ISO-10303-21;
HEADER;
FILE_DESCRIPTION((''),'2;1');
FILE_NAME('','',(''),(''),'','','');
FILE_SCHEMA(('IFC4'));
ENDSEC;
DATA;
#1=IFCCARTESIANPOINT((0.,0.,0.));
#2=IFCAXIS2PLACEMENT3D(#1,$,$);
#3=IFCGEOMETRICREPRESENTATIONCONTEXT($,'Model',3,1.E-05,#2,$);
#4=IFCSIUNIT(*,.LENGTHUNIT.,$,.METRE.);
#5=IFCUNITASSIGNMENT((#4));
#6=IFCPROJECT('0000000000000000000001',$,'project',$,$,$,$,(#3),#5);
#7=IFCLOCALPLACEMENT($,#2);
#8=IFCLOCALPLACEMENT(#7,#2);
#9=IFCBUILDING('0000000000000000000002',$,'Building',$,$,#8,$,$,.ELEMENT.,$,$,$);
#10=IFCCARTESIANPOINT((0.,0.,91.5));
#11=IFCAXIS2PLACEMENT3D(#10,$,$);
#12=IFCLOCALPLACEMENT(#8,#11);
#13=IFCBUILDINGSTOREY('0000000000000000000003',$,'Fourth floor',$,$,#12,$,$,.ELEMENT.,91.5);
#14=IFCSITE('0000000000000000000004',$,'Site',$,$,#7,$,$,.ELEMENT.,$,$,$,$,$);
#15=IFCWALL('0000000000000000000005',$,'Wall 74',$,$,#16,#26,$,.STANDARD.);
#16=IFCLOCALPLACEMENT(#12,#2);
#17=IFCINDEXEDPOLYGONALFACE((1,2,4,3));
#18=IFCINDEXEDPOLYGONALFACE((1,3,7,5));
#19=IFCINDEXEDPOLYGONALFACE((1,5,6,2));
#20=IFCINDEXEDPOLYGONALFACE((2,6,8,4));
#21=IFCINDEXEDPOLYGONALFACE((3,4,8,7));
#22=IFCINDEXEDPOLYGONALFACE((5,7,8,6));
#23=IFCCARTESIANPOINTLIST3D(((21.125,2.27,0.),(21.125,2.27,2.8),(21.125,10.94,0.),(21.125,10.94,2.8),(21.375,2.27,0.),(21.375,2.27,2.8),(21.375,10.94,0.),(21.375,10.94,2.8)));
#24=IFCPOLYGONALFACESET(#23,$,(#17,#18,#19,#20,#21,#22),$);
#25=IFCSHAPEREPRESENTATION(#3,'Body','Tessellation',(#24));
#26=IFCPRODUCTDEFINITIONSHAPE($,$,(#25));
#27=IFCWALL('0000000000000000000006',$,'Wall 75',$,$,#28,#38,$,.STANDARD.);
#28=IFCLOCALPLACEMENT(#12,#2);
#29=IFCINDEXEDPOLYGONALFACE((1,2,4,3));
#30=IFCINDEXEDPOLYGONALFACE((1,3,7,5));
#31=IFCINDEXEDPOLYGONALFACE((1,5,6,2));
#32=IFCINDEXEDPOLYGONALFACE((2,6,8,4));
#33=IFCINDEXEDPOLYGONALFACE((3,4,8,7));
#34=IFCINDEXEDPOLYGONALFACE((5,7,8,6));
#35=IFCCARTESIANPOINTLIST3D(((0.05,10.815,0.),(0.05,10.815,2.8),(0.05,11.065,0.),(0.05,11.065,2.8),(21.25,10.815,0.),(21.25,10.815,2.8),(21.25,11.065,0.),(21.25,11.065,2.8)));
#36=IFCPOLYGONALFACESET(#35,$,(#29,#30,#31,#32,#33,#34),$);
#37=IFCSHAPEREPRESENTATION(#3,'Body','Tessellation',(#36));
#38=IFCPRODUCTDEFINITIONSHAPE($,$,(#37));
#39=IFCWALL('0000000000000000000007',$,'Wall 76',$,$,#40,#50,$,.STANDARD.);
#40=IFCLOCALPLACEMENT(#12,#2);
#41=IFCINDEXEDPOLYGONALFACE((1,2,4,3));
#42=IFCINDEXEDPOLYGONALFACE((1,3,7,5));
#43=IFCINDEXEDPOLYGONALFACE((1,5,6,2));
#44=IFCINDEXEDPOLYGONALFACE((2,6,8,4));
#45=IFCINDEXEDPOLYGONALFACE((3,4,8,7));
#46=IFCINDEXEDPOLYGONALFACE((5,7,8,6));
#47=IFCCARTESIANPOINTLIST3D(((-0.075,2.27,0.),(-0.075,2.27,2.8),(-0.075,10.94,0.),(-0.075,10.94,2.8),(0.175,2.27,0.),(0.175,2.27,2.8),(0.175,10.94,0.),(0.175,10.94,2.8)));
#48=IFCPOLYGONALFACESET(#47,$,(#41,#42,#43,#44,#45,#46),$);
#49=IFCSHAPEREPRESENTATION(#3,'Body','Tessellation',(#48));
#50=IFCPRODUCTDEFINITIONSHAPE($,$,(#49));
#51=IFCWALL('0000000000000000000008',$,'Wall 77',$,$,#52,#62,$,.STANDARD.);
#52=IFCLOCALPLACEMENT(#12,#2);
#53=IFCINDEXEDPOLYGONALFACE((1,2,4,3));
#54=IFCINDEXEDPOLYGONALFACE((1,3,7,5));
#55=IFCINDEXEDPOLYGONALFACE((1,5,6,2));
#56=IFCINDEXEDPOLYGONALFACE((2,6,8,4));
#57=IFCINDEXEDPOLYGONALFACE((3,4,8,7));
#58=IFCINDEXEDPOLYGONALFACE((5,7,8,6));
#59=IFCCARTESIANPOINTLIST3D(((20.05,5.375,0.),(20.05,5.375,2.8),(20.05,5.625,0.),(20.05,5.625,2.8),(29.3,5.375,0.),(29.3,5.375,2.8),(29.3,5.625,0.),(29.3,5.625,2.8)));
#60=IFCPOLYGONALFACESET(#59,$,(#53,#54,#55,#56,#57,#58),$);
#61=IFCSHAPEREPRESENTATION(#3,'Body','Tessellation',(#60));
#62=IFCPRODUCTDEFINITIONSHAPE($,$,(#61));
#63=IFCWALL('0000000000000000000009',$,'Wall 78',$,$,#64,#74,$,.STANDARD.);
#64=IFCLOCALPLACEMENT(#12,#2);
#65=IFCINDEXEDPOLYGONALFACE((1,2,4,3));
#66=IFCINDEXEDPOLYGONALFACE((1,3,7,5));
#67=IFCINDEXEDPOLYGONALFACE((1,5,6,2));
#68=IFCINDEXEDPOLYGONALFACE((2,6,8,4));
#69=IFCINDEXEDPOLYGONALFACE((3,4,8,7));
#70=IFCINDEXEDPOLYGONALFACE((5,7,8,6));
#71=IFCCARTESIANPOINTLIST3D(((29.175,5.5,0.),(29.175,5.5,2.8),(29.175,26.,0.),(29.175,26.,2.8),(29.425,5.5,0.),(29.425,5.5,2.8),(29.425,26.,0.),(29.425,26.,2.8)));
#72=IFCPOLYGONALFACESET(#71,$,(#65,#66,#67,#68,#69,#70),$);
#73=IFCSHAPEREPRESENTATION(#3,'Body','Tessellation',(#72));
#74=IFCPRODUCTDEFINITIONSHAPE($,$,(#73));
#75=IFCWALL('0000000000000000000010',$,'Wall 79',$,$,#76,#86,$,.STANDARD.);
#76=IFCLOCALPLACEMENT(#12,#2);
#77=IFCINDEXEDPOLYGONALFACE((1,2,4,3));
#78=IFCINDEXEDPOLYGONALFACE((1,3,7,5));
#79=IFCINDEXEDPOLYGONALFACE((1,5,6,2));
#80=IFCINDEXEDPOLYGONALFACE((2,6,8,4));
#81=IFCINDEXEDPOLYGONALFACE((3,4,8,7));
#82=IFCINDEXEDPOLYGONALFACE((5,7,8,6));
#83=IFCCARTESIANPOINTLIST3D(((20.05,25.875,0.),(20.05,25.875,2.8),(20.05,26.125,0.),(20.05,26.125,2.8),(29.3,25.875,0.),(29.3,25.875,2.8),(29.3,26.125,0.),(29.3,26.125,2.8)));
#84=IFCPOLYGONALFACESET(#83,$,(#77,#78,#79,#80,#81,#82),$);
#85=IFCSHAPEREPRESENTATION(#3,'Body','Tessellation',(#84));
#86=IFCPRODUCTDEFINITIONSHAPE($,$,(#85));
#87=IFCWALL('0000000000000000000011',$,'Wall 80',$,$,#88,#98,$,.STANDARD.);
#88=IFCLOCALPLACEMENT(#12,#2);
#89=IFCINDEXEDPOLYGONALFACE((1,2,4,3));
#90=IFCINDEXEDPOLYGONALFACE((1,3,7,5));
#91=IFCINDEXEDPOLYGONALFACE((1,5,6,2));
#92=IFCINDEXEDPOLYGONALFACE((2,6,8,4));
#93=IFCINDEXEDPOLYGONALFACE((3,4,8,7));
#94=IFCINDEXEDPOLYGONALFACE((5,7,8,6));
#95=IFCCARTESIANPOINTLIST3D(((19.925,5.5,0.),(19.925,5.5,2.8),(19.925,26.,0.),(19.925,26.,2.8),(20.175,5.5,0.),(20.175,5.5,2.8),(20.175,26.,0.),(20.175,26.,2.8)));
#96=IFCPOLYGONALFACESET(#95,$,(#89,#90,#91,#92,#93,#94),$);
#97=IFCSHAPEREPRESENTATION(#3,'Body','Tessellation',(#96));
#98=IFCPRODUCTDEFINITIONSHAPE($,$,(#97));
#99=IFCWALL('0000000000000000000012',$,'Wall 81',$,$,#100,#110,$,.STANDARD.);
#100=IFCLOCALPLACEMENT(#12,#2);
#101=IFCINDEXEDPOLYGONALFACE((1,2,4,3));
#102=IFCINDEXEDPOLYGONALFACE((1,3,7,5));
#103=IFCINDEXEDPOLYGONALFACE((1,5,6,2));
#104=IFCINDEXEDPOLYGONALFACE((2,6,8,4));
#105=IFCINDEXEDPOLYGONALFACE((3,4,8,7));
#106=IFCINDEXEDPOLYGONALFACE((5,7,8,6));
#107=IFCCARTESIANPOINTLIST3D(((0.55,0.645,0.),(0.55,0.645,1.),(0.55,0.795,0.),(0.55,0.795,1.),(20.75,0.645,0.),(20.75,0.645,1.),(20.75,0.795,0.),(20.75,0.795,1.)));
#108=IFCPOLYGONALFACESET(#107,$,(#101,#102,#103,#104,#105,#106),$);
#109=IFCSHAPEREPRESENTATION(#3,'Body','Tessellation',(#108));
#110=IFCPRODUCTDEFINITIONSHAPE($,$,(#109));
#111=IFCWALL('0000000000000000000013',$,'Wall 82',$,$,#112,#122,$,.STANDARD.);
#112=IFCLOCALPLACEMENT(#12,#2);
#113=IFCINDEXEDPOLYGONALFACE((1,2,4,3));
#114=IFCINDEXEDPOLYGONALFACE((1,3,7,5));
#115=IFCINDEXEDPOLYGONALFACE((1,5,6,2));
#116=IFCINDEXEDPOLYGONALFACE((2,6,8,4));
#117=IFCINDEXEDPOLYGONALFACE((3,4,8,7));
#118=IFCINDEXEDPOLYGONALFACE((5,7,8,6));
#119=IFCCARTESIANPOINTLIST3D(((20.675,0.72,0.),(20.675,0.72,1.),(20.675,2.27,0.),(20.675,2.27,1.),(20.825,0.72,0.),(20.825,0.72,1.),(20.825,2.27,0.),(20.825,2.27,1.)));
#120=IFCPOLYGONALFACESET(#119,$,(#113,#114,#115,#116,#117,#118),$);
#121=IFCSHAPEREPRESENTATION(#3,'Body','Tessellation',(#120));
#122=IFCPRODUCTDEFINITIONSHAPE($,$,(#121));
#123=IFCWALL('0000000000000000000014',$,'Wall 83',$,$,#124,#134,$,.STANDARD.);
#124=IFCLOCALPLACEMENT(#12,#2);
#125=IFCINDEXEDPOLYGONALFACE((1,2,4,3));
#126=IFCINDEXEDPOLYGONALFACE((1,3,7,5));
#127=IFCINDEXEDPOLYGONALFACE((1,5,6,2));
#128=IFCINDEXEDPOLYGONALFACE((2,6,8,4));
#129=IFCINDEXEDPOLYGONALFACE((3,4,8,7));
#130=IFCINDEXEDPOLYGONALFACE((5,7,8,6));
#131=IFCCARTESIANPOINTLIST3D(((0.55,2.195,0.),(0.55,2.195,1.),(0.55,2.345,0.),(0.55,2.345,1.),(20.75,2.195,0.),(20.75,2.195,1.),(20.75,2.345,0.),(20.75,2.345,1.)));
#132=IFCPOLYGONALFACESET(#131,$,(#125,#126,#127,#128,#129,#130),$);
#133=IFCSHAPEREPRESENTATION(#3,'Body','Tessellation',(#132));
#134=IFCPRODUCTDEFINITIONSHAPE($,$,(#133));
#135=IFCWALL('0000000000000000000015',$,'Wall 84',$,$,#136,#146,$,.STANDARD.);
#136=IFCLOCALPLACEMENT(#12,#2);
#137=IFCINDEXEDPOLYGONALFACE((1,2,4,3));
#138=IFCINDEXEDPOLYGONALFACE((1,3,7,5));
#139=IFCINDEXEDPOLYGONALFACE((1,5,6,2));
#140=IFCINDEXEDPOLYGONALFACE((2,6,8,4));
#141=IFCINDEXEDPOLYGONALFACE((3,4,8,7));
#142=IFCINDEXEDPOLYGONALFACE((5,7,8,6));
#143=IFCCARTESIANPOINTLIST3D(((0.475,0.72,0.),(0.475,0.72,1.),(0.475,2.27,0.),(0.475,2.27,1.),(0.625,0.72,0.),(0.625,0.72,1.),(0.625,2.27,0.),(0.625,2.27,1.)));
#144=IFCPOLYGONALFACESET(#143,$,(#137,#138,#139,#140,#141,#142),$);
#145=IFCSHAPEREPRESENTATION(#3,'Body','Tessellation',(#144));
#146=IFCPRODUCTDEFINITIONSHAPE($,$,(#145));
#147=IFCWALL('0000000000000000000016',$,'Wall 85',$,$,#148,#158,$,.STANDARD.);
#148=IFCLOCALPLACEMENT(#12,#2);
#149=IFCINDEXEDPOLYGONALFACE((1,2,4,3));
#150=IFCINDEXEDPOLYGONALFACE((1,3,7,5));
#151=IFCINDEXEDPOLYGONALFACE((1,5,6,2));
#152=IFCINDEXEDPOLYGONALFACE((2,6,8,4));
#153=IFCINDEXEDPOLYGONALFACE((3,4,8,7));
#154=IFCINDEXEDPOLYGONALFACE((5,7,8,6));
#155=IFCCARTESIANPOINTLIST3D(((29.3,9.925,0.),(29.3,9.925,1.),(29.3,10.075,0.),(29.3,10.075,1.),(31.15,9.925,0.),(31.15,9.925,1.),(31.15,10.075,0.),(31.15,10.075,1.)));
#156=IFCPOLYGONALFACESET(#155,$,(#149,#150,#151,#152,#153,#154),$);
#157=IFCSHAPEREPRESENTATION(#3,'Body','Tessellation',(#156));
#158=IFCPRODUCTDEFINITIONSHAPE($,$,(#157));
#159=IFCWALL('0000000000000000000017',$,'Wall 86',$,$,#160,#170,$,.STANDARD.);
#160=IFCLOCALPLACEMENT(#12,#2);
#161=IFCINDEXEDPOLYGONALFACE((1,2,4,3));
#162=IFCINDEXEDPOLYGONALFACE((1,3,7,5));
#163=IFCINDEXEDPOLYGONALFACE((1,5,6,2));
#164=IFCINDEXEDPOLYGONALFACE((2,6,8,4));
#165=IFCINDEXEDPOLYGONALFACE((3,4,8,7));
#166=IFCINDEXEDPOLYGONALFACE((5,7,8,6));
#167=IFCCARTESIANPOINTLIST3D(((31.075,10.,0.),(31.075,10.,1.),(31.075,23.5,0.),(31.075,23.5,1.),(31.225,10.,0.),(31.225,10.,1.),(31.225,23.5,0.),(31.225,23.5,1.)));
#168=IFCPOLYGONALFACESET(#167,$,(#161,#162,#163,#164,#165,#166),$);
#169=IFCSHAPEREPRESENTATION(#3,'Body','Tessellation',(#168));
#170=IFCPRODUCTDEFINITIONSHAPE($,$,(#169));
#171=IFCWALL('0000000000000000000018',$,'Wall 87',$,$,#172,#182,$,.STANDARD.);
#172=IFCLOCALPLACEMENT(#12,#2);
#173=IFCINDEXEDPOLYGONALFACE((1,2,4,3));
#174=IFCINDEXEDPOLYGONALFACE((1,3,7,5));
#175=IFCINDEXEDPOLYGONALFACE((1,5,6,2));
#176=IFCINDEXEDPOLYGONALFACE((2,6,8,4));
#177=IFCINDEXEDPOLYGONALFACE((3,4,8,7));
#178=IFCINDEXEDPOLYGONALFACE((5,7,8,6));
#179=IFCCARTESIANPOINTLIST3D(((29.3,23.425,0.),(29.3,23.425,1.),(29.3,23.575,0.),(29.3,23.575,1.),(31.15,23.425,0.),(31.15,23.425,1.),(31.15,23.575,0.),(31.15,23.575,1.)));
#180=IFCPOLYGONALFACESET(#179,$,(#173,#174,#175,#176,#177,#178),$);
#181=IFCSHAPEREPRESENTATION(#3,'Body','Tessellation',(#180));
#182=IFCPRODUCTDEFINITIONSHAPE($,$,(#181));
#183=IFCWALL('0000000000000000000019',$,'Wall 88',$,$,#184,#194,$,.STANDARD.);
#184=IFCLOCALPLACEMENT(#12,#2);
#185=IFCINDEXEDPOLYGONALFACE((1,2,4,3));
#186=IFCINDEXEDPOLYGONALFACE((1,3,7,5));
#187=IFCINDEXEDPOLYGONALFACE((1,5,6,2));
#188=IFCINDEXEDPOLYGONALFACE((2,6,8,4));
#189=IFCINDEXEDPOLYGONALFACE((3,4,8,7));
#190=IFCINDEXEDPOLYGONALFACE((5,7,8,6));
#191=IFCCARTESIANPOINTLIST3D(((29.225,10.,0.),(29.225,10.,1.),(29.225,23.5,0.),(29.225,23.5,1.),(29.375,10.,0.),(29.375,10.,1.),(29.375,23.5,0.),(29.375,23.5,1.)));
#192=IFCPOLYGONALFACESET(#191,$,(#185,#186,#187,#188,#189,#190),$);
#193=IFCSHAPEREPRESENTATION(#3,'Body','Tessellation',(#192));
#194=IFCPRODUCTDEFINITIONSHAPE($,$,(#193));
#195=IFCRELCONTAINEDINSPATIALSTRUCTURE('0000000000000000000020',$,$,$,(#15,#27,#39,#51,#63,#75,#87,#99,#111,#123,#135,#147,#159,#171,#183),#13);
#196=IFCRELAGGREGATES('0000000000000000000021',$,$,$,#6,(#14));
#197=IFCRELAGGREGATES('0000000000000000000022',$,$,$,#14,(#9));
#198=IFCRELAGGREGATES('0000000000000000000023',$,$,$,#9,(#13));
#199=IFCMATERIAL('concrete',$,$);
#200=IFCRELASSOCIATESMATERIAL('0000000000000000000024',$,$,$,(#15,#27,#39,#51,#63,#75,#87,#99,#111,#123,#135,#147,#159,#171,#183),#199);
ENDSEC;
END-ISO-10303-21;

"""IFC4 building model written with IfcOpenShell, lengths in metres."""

from ifc_helpers import new_model, si_unit, frame, frame_2d, origin, place, context, project, spatial, rectangle, extrude, material, element, save


model = new_model("IFC4")

# Units and contexts
model_context = context("Model", 3, precision=1e-05, world=origin())
ifc_project = project(units=[si_unit("LENGTHUNIT", "METRE")], contexts=[model_context])

# Site, building, storey
site_placement = place(None, origin())
site = spatial("IfcSite", under=ifc_project, at=site_placement, Name="Site", CompositionType="ELEMENT")
building_placement = place(site_placement, origin())
building = spatial("IfcBuilding", under=site, at=building_placement, Name="Building", CompositionType="ELEMENT")
storey_placement = place(building_placement, frame((0.0, 0.0, 91.5)))
storey = spatial("IfcBuildingStorey", under=building, at=storey_placement, Name="Fourth floor", CompositionType="ELEMENT", Elevation=91.5)

# Shared definitions
ifc_material = material(Name="concrete")

# Walls
wall_1_placement = place(storey_placement, frame((21.25, 2.27, 0.0), z_axis=(0.0, 0.0, 1.0), x_axis=(0.0, 1.0, 0.0)))
element("IfcWall", 1, at=wall_1_placement, inside=storey, material=ifc_material, Name="Wall 74", PredefinedType="STANDARD", context=model_context, shape_type="SweptSolid", body=[
    extrude(rectangle(XDim=8.67, YDim=0.25, at=frame_2d((4.335, 0.0))), origin(), (0.0, 0.0, 1.0), 2.8),
])
wall_2_placement = place(storey_placement, frame((21.25, 10.94, 0.0), z_axis=(0.0, 0.0, 1.0), x_axis=(-1.0, 0.0, 0.0)))
element("IfcWall", 2, at=wall_2_placement, inside=storey, material=ifc_material, Name="Wall 75", PredefinedType="STANDARD", context=model_context, shape_type="SweptSolid", body=[
    extrude(rectangle(XDim=21.2, YDim=0.25, at=frame_2d((10.6, 0.0))), origin(), (0.0, 0.0, 1.0), 2.8),
])
wall_3_placement = place(storey_placement, frame((0.05, 10.94, 0.0), z_axis=(0.0, 0.0, 1.0), x_axis=(0.0, -1.0, 0.0)))
element("IfcWall", 3, at=wall_3_placement, inside=storey, material=ifc_material, Name="Wall 76", PredefinedType="STANDARD", context=model_context, shape_type="SweptSolid", body=[
    extrude(rectangle(XDim=8.67, YDim=0.25, at=frame_2d((4.335, 0.0))), origin(), (0.0, 0.0, 1.0), 2.8),
])
wall_4_placement = place(storey_placement, frame((20.05, 5.5, 0.0), z_axis=(0.0, 0.0, 1.0), x_axis=(1.0, 0.0, 0.0)))
element("IfcWall", 4, at=wall_4_placement, inside=storey, material=ifc_material, Name="Wall 77", PredefinedType="STANDARD", context=model_context, shape_type="SweptSolid", body=[
    extrude(rectangle(XDim=9.25, YDim=0.25, at=frame_2d((4.625, 0.0))), origin(), (0.0, 0.0, 1.0), 2.8),
])
wall_5_placement = place(storey_placement, frame((29.3, 5.5, 0.0), z_axis=(0.0, 0.0, 1.0), x_axis=(0.0, 1.0, 0.0)))
element("IfcWall", 5, at=wall_5_placement, inside=storey, material=ifc_material, Name="Wall 78", PredefinedType="STANDARD", context=model_context, shape_type="SweptSolid", body=[
    extrude(rectangle(XDim=20.5, YDim=0.25, at=frame_2d((10.25, 0.0))), origin(), (0.0, 0.0, 1.0), 2.8),
])
wall_6_placement = place(storey_placement, frame((29.3, 26.0, 0.0), z_axis=(0.0, 0.0, 1.0), x_axis=(-1.0, 0.0, 0.0)))
element("IfcWall", 6, at=wall_6_placement, inside=storey, material=ifc_material, Name="Wall 79", PredefinedType="STANDARD", context=model_context, shape_type="SweptSolid", body=[
    extrude(rectangle(XDim=9.25, YDim=0.25, at=frame_2d((4.625, 0.0))), origin(), (0.0, 0.0, 1.0), 2.8),
])
wall_7_placement = place(storey_placement, frame((20.05, 26.0, 0.0), z_axis=(0.0, 0.0, 1.0), x_axis=(0.0, -1.0, 0.0)))
element("IfcWall", 7, at=wall_7_placement, inside=storey, material=ifc_material, Name="Wall 80", PredefinedType="STANDARD", context=model_context, shape_type="SweptSolid", body=[
    extrude(rectangle(XDim=20.5, YDim=0.25, at=frame_2d((10.25, 0.0))), origin(), (0.0, 0.0, 1.0), 2.8),
])
wall_8_placement = place(storey_placement, frame((0.55, 0.72, 0.0), z_axis=(0.0, 0.0, 1.0), x_axis=(1.0, 0.0, 0.0)))
element("IfcWall", 8, at=wall_8_placement, inside=storey, material=ifc_material, Name="Wall 81", PredefinedType="STANDARD", context=model_context, shape_type="SweptSolid", body=[
    extrude(rectangle(XDim=20.2, YDim=0.15, at=frame_2d((10.1, 0.0))), origin(), (0.0, 0.0, 1.0), 1.0),
])
wall_9_placement = place(storey_placement, frame((20.75, 0.72, 0.0), z_axis=(0.0, 0.0, 1.0), x_axis=(0.0, 1.0, 0.0)))
element("IfcWall", 9, at=wall_9_placement, inside=storey, material=ifc_material, Name="Wall 82", PredefinedType="STANDARD", context=model_context, shape_type="SweptSolid", body=[
    extrude(rectangle(XDim=1.55, YDim=0.15, at=frame_2d((0.775, 0.0))), origin(), (0.0, 0.0, 1.0), 1.0),
])
wall_10_placement = place(storey_placement, frame((20.75, 2.27, 0.0), z_axis=(0.0, 0.0, 1.0), x_axis=(-1.0, 0.0, 0.0)))
element("IfcWall", 10, at=wall_10_placement, inside=storey, material=ifc_material, Name="Wall 83", PredefinedType="STANDARD", context=model_context, shape_type="SweptSolid", body=[
    extrude(rectangle(XDim=20.2, YDim=0.15, at=frame_2d((10.1, 0.0))), origin(), (0.0, 0.0, 1.0), 1.0),
])
wall_11_placement = place(storey_placement, frame((0.55, 2.27, 0.0), z_axis=(0.0, 0.0, 1.0), x_axis=(0.0, -1.0, 0.0)))
element("IfcWall", 11, at=wall_11_placement, inside=storey, material=ifc_material, Name="Wall 84", PredefinedType="STANDARD", context=model_context, shape_type="SweptSolid", body=[
    extrude(rectangle(XDim=1.55, YDim=0.15, at=frame_2d((0.775, 0.0))), origin(), (0.0, 0.0, 1.0), 1.0),
])
wall_12_placement = place(storey_placement, frame((29.3, 10.0, 0.0), z_axis=(0.0, 0.0, 1.0), x_axis=(1.0, 0.0, 0.0)))
element("IfcWall", 12, at=wall_12_placement, inside=storey, material=ifc_material, Name="Wall 85", PredefinedType="STANDARD", context=model_context, shape_type="SweptSolid", body=[
    extrude(rectangle(XDim=1.85, YDim=0.15, at=frame_2d((0.925, 0.0))), origin(), (0.0, 0.0, 1.0), 1.0),
])
wall_13_placement = place(storey_placement, frame((31.15, 10.0, 0.0), z_axis=(0.0, 0.0, 1.0), x_axis=(0.0, 1.0, 0.0)))
element("IfcWall", 13, at=wall_13_placement, inside=storey, material=ifc_material, Name="Wall 86", PredefinedType="STANDARD", context=model_context, shape_type="SweptSolid", body=[
    extrude(rectangle(XDim=13.5, YDim=0.15, at=frame_2d((6.75, 0.0))), origin(), (0.0, 0.0, 1.0), 1.0),
])
wall_14_placement = place(storey_placement, frame((31.15, 23.5, 0.0), z_axis=(0.0, 0.0, 1.0), x_axis=(-1.0, 0.0, 0.0)))
element("IfcWall", 14, at=wall_14_placement, inside=storey, material=ifc_material, Name="Wall 87", PredefinedType="STANDARD", context=model_context, shape_type="SweptSolid", body=[
    extrude(rectangle(XDim=1.85, YDim=0.15, at=frame_2d((0.925, 0.0))), origin(), (0.0, 0.0, 1.0), 1.0),
])
wall_15_placement = place(storey_placement, frame((29.3, 23.5, 0.0), z_axis=(0.0, 0.0, 1.0), x_axis=(0.0, -1.0, 0.0)))
element("IfcWall", 15, at=wall_15_placement, inside=storey, material=ifc_material, Name="Wall 88", PredefinedType="STANDARD", context=model_context, shape_type="SweptSolid", body=[
    extrude(rectangle(XDim=13.5, YDim=0.15, at=frame_2d((6.75, 0.0))), origin(), (0.0, 0.0, 1.0), 1.0),
])

save(model, "model.ifc")
